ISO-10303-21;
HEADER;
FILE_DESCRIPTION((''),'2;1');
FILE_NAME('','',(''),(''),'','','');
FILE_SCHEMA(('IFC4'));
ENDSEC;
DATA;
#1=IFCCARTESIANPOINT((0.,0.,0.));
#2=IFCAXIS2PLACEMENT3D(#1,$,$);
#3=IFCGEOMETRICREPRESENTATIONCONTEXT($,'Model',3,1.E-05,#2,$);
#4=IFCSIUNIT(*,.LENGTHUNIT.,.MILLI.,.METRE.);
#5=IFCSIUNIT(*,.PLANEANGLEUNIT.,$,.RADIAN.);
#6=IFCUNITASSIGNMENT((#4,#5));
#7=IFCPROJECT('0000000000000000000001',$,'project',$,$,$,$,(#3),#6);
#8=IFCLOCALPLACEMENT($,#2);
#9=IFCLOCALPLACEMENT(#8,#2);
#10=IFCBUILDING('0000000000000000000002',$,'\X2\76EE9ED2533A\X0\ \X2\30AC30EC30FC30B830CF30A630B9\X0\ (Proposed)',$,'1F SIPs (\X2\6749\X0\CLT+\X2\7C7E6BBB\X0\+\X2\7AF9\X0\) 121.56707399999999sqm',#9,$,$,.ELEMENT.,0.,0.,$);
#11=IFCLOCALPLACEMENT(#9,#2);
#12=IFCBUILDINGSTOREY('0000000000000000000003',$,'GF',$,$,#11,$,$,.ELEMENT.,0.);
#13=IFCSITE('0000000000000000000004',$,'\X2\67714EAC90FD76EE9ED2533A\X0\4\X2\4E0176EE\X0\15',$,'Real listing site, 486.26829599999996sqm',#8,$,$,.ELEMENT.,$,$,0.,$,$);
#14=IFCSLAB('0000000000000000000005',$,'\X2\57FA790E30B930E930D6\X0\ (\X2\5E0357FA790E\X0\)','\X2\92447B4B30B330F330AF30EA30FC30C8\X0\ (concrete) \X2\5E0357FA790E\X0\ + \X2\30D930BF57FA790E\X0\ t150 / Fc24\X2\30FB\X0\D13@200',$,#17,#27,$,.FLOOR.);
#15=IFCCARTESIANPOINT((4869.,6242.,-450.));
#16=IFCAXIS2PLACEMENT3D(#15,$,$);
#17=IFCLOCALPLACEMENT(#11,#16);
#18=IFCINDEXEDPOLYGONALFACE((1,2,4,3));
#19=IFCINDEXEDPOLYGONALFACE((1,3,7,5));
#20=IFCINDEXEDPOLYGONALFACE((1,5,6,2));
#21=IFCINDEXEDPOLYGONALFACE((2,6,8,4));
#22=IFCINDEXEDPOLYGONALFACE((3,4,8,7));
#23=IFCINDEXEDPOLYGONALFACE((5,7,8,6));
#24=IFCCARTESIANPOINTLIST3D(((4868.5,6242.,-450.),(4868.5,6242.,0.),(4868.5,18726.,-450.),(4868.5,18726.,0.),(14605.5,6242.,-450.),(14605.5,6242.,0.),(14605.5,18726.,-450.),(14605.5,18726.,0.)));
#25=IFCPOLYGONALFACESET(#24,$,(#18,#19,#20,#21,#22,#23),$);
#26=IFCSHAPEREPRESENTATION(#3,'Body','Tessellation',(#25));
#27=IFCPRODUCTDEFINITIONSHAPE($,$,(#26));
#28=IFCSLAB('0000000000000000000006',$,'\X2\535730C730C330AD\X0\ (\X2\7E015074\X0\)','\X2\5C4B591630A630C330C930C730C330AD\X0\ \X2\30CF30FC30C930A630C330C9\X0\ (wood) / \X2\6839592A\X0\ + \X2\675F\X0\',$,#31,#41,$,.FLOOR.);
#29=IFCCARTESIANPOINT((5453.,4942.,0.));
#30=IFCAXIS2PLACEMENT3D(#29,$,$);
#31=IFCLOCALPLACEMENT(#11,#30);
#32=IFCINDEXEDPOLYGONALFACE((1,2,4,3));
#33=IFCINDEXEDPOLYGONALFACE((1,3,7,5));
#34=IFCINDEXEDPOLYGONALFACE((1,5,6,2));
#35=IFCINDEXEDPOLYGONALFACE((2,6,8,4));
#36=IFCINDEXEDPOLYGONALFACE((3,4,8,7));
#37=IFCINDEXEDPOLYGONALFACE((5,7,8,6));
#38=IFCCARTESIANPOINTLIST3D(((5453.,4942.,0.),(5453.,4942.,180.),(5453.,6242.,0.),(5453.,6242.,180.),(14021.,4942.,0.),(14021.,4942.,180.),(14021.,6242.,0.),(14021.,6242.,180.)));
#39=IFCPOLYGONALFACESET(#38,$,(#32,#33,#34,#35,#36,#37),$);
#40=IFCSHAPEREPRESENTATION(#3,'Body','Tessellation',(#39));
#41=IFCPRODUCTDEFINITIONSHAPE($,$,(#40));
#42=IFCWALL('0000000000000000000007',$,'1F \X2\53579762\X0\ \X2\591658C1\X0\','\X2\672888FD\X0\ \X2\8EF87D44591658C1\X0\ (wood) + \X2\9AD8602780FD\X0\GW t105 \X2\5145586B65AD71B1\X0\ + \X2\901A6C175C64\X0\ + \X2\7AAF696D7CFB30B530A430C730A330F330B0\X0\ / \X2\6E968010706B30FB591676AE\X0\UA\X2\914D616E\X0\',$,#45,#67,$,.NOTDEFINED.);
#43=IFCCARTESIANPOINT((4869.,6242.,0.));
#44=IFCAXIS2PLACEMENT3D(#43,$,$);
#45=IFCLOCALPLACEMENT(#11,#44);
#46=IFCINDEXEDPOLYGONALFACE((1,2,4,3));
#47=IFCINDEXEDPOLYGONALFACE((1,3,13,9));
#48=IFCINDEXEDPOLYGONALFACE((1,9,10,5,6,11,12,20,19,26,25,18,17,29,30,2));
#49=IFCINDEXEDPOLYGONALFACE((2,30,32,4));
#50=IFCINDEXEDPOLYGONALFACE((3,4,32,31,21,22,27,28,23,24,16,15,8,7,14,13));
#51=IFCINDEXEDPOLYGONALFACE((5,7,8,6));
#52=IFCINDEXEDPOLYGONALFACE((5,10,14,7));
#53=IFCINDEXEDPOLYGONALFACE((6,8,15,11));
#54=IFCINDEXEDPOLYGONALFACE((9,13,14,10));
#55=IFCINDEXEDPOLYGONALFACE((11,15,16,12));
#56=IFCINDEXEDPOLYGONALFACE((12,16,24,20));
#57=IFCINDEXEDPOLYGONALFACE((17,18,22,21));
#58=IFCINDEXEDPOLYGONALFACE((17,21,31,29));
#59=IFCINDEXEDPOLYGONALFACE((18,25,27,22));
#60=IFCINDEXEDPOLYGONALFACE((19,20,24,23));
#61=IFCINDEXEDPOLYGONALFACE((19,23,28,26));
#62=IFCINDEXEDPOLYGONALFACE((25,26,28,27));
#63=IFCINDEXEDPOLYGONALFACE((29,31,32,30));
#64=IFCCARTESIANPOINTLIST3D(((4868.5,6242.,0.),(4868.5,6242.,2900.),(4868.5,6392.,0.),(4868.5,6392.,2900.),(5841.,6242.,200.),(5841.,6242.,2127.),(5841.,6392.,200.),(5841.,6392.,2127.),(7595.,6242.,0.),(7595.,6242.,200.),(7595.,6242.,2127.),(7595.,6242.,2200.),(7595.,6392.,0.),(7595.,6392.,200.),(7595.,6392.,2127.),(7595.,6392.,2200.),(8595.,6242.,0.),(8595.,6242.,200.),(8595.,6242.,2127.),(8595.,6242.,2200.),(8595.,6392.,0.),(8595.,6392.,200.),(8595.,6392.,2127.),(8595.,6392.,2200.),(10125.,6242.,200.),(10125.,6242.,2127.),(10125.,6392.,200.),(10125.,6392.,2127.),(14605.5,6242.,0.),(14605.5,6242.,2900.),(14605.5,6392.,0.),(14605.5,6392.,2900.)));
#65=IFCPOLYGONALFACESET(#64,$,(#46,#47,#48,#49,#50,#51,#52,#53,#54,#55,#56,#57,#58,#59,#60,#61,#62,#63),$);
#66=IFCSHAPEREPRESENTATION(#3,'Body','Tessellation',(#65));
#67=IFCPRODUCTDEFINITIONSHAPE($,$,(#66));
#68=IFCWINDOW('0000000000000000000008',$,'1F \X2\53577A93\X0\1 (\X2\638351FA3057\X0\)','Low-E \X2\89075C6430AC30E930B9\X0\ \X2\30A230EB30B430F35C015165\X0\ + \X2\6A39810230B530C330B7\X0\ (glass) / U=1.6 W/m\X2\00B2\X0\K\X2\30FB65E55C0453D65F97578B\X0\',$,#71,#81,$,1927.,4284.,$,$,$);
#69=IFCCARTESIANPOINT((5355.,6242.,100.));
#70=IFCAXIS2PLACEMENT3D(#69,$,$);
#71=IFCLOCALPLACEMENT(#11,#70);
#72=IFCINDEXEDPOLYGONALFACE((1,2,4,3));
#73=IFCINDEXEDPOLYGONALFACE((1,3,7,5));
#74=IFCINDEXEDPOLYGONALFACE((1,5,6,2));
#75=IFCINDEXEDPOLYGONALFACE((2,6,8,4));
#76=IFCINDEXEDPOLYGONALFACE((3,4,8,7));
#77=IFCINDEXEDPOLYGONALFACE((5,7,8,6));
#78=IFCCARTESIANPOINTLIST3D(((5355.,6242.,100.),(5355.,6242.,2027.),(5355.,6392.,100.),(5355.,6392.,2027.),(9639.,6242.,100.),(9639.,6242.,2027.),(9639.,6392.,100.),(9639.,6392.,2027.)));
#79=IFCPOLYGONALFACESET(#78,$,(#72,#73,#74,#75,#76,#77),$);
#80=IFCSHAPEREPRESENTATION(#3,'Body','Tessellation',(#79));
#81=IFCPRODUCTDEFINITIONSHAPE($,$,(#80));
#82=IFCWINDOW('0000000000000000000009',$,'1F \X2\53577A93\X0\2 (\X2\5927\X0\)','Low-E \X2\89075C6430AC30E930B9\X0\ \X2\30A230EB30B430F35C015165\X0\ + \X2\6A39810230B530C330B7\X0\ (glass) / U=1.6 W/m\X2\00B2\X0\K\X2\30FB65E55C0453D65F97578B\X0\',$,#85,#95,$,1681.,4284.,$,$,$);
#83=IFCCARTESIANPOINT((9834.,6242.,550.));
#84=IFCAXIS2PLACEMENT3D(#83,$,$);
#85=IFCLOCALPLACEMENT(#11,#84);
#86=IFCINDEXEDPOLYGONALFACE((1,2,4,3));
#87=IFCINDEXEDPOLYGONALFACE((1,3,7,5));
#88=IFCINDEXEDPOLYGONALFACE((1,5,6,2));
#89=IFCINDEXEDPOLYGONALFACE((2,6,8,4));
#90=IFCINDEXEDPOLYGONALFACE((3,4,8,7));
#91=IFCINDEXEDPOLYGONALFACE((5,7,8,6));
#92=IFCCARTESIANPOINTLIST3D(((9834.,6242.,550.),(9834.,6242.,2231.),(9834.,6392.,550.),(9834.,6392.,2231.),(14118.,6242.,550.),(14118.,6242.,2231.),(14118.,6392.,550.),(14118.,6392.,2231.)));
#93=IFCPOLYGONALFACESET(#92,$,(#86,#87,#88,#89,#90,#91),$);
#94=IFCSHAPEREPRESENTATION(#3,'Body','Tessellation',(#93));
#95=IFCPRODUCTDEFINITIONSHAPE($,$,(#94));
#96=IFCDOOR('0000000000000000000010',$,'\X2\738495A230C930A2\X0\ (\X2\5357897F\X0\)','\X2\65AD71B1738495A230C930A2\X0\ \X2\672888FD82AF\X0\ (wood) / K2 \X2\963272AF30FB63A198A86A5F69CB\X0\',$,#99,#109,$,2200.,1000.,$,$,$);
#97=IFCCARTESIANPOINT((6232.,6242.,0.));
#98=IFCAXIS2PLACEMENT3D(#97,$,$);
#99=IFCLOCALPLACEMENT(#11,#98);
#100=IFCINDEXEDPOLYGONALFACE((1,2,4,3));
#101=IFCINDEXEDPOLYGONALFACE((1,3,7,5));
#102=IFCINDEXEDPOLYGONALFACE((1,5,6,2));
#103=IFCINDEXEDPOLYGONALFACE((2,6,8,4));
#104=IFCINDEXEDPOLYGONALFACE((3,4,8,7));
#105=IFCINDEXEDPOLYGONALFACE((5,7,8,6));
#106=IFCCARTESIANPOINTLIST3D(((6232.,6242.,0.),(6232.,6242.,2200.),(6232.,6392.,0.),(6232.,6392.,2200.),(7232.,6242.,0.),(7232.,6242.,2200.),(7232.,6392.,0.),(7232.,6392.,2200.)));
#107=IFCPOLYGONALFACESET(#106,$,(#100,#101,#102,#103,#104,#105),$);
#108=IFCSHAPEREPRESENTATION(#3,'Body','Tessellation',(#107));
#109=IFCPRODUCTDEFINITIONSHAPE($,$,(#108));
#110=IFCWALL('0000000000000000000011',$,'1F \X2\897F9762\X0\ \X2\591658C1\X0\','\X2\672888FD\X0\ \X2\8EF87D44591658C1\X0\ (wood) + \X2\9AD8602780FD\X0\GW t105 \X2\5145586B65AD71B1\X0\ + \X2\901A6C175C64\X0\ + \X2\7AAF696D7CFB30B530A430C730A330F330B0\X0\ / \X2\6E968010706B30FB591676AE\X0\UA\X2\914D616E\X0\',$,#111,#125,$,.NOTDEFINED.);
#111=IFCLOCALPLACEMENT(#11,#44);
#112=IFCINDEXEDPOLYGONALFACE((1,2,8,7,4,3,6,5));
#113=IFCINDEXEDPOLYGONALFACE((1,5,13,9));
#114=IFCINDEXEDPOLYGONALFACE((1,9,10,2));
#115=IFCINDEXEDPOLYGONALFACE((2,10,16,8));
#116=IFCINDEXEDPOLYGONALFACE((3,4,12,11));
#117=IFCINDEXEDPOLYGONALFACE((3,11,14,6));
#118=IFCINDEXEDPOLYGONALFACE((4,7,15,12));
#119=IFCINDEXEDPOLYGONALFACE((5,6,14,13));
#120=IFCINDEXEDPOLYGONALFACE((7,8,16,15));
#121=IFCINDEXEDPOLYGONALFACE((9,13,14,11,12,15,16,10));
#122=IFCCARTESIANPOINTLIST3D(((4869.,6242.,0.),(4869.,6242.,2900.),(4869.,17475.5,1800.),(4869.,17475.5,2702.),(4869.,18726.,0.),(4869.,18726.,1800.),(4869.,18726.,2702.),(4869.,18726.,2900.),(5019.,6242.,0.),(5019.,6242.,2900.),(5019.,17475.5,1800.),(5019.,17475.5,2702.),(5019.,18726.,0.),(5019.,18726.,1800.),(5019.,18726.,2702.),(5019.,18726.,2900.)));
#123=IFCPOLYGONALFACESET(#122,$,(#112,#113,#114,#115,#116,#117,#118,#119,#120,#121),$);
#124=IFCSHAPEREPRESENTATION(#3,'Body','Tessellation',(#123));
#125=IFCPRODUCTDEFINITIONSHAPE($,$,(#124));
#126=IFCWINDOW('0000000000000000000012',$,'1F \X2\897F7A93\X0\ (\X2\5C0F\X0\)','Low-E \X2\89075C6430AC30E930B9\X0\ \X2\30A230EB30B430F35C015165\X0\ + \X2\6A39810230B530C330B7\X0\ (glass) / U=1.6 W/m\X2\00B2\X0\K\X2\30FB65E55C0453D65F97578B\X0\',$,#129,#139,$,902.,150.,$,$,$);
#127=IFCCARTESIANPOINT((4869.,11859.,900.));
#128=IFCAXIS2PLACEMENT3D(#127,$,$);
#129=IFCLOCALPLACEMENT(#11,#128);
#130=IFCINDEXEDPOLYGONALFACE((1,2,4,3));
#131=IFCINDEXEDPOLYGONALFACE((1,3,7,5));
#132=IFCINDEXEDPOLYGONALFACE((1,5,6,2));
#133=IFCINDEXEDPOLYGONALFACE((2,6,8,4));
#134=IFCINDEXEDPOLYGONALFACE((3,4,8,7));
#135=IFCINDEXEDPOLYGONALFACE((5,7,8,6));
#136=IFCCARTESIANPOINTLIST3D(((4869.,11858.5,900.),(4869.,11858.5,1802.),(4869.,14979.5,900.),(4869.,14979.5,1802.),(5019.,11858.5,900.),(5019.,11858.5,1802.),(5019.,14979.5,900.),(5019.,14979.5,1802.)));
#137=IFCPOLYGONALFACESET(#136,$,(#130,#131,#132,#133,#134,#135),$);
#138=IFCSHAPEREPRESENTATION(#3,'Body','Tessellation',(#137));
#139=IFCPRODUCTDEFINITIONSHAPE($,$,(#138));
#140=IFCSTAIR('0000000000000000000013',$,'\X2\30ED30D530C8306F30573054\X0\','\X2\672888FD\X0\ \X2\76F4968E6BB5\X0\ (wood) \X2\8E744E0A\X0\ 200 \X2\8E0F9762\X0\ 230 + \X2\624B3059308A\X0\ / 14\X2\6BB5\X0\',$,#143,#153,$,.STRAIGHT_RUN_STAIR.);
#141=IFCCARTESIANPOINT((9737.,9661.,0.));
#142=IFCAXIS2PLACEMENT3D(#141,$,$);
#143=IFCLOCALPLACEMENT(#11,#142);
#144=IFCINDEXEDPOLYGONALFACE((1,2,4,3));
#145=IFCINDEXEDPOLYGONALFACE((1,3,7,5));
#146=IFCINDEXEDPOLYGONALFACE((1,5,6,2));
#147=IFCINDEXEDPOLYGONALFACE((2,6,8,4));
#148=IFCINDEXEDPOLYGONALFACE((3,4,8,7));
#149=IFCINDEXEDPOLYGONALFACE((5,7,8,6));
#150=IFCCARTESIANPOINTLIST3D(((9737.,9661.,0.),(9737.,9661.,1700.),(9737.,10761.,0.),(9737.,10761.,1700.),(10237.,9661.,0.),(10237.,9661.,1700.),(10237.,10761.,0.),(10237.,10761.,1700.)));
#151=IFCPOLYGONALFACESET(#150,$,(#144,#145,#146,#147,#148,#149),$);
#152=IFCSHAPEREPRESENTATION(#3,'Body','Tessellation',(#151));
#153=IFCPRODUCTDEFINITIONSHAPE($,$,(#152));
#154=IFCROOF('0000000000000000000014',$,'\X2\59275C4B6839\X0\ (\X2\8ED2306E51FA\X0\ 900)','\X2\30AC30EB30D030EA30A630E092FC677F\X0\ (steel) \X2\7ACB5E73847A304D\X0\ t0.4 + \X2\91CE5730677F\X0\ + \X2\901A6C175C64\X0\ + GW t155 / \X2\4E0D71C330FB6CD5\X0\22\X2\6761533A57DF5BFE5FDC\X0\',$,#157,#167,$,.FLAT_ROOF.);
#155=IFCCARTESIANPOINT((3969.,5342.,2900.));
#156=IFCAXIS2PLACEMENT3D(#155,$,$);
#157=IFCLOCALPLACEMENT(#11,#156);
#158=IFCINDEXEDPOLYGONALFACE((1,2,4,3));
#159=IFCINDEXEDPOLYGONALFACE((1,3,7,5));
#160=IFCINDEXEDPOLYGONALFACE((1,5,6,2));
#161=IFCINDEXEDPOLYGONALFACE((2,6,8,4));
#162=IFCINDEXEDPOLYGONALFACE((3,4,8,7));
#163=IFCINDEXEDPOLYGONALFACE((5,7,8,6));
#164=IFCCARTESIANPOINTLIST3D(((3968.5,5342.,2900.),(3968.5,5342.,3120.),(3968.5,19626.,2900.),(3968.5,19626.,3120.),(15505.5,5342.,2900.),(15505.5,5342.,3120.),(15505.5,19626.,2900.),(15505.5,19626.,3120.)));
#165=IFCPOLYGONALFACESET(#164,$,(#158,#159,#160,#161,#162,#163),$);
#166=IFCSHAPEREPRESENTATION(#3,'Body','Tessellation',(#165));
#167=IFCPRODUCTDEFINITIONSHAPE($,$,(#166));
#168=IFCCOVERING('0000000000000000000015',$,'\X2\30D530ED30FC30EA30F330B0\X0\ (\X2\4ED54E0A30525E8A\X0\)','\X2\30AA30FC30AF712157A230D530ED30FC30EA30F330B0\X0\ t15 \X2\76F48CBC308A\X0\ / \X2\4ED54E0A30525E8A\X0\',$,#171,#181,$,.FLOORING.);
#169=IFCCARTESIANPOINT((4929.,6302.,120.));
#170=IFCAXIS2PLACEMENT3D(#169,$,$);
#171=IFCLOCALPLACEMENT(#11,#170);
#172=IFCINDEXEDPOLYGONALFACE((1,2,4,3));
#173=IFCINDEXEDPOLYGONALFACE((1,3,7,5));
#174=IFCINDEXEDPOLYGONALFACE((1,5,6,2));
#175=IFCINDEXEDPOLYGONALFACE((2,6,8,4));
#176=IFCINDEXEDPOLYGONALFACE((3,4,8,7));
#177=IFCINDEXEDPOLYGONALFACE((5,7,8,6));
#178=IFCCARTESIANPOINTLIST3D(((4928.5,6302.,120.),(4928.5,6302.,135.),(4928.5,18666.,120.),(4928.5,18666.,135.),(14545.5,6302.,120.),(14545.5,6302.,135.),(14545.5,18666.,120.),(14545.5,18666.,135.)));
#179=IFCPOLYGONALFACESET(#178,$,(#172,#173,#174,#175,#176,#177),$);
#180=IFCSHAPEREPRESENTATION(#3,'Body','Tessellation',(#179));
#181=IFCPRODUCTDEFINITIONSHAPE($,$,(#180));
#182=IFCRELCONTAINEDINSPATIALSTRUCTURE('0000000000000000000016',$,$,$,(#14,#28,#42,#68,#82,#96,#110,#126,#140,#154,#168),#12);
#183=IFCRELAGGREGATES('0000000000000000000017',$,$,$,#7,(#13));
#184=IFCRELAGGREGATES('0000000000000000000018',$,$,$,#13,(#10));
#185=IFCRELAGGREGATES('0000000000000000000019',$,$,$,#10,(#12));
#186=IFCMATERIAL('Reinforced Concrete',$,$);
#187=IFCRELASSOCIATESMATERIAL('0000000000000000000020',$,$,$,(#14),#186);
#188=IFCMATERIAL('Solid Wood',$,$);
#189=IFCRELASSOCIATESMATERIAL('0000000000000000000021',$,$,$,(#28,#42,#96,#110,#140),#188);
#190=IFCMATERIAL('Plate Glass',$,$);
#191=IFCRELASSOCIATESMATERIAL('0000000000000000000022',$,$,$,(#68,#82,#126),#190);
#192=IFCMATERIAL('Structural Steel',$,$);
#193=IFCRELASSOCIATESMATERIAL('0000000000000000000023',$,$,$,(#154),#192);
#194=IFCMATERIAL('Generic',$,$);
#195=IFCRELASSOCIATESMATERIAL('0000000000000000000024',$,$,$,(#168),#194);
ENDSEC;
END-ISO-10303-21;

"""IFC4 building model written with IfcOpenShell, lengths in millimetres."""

from ifc_helpers import new_model, si_unit, frame, frame_2d, origin, place, context, project, spatial, rectangle, extrude, material, element, fill, save


model = new_model("IFC4")

# Units and contexts
model_context = context("Model", 3, precision=1e-05, world=origin())
ifc_project = project(units=[si_unit("LENGTHUNIT", "METRE", prefix="MILLI"), si_unit("PLANEANGLEUNIT", "RADIAN")], contexts=[model_context])

# Site, building, storey
site_placement = place(None, origin())
site = spatial("IfcSite", under=ifc_project, at=site_placement, Name="東京都目黒区4丁目15", ObjectType="Real listing site, 486.26829599999996sqm", CompositionType="ELEMENT", RefElevation=0.0)
building_placement = place(site_placement, origin())
building = spatial("IfcBuilding", under=site, at=building_placement, Name="目黒区 ガレージハウス (Proposed)", ObjectType="1F SIPs (杉CLT+籾殻+竹) 121.56707399999999sqm", CompositionType="ELEMENT", ElevationOfRefHeight=0.0, ElevationOfTerrain=0.0)
storey_placement = place(building_placement, origin())
storey = spatial("IfcBuildingStorey", under=building, at=storey_placement, Name="GF", CompositionType="ELEMENT", Elevation=0.0)

# Slabs
ifc_material_1 = material(Name="Reinforced Concrete")
slab_1_placement = place(storey_placement, frame((4869.0, 6242.0, -450.0)))
element("IfcSlab", 1, at=slab_1_placement, inside=storey, material=ifc_material_1, Name="基礎スラブ (布基礎)", Description="鉄筋コンクリート (concrete) 布基礎 + ベタ基礎 t150 / Fc24・D13@200", PredefinedType="FLOOR", context=model_context, shape_type="SweptSolid", body=[
    extrude(rectangle(XDim=9737.0, YDim=12484.0, at=frame_2d((4868.0, 6242.0))), frame((4869.0, 6242.0, -450.0)), (0.0, 0.0, 1.0), 450.0),
])
ifc_material_2 = material(Name="Solid Wood")
slab_2_placement = place(storey_placement, frame((5453.0, 4942.0, 0.0)))
element("IfcSlab", 2, at=slab_2_placement, inside=storey, material=ifc_material_2, Name="南デッキ (縁側)", Description="屋外ウッドデッキ ハードウッド (wood) / 根太 + 束", PredefinedType="FLOOR", context=model_context, shape_type="SweptSolid", body=[
    extrude(rectangle(XDim=8568.0, YDim=1300.0, at=frame_2d((4284.0, 650.0))), frame((5453.0, 4942.0, 0.0)), (0.0, 0.0, 1.0), 180.0),
])

# Wall, openings, windows, door
wall_1_placement = place(storey_placement, frame((4869.0, 6242.0, 0.0)))
wall_1 = element("IfcWall", 3, at=wall_1_placement, inside=storey, material=ifc_material_2, Name="1F 南面 外壁", Description="木製 軸組外壁 (wood) + 高性能GW t105 充填断熱 + 通気層 + 窯業系サイディング / 準耐火・外皮UA配慮", PredefinedType="NOTDEFINED", context=model_context, shape_type="SweptSolid", body=[
    extrude(rectangle(XDim=9737.0, YDim=150.0, at=frame_2d((4868.0, 75.0))), frame((4869.0, 6242.0, 0.0)), (0.0, 0.0, 1.0), 2900.0),
])
opening_1_placement = place(storey_placement, frame((5355.0, 6242.0, 100.0)))
opening_1 = element("IfcOpeningElement", 4, at=opening_1_placement, cuts=wall_1, PredefinedType="NOTDEFINED", context=model_context, shape_type="SweptSolid", body=[
    extrude(rectangle(XDim=4284.0, YDim=150.0, at=frame_2d((2142.0, 75.0))), frame((5355.0, 6242.0, 100.0)), (0.0, 0.0, 1.0), 1927.0),
])
opening_2_placement = place(storey_placement, frame((9834.0, 6242.0, 550.0)))
opening_2 = element("IfcOpeningElement", 5, at=opening_2_placement, cuts=wall_1, PredefinedType="NOTDEFINED", context=model_context, shape_type="SweptSolid", body=[
    extrude(rectangle(XDim=4284.0, YDim=150.0, at=frame_2d((2142.0, 75.0))), frame((9834.0, 6242.0, 550.0)), (0.0, 0.0, 1.0), 1681.0),
])
opening_3_placement = place(storey_placement, frame((6232.0, 6242.0, 0.0)))
opening_3 = element("IfcOpeningElement", 6, at=opening_3_placement, cuts=wall_1, PredefinedType="NOTDEFINED", context=model_context, shape_type="SweptSolid", body=[
    extrude(rectangle(XDim=1000.0, YDim=150.0, at=frame_2d((500.0, 75.0))), frame((6232.0, 6242.0, 0.0)), (0.0, 0.0, 1.0), 2200.0),
])
ifc_material_3 = material(Name="Plate Glass")
window_1_placement = place(storey_placement, frame((5355.0, 6242.0, 100.0)))
window_1 = element("IfcWindow", 7, at=window_1_placement, inside=storey, material=ifc_material_3, Name="1F 南窓1 (掃出し)", Description="Low-E 複層ガラス アルゴン封入 + 樹脂サッシ (glass) / U=1.6 W/m²K・日射取得型", OverallHeight=1927.0, OverallWidth=4284.0, context=model_context, shape_type="SweptSolid", body=[
    extrude(rectangle(XDim=4284.0, YDim=150.0, at=frame_2d((2142.0, 75.0))), frame((5355.0, 6242.0, 100.0)), (0.0, 0.0, 1.0), 1927.0),
])
fill(opening_1, window_1)
window_2_placement = place(storey_placement, frame((9834.0, 6242.0, 550.0)))
window_2 = element("IfcWindow", 8, at=window_2_placement, inside=storey, material=ifc_material_3, Name="1F 南窓2 (大)", Description="Low-E 複層ガラス アルゴン封入 + 樹脂サッシ (glass) / U=1.6 W/m²K・日射取得型", OverallHeight=1681.0, OverallWidth=4284.0, context=model_context, shape_type="SweptSolid", body=[
    extrude(rectangle(XDim=4284.0, YDim=150.0, at=frame_2d((2142.0, 75.0))), frame((9834.0, 6242.0, 550.0)), (0.0, 0.0, 1.0), 1681.0),
])
fill(opening_2, window_2)
door_placement = place(storey_placement, frame((6232.0, 6242.0, 0.0)))
door = element("IfcDoor", 9, at=door_placement, inside=storey, material=ifc_material_2, Name="玄関ドア (南西)", Description="断熱玄関ドア 木製芯 (wood) / K2 防犯・採風機構", OverallHeight=2200.0, OverallWidth=1000.0, context=model_context, shape_type="SweptSolid", body=[
    extrude(rectangle(XDim=1000.0, YDim=150.0, at=frame_2d((500.0, 75.0))), frame((6232.0, 6242.0, 0.0)), (0.0, 0.0, 1.0), 2200.0),
])
fill(opening_3, door)

# Wall, opening, window
wall_2_placement = place(storey_placement, frame((4869.0, 6242.0, 0.0)))
wall_2 = element("IfcWall", 10, at=wall_2_placement, inside=storey, material=ifc_material_2, Name="1F 西面 外壁", Description="木製 軸組外壁 (wood) + 高性能GW t105 充填断熱 + 通気層 + 窯業系サイディング / 準耐火・外皮UA配慮", PredefinedType="NOTDEFINED", context=model_context, shape_type="SweptSolid", body=[
    extrude(rectangle(XDim=150.0, YDim=12484.0, at=frame_2d((75.0, 6242.0))), frame((4869.0, 6242.0, 0.0)), (0.0, 0.0, 1.0), 2900.0),
])
opening_4_placement = place(storey_placement, frame((4869.0, 11859.0, 900.0)))
opening_4 = element("IfcOpeningElement", 11, at=opening_4_placement, cuts=wall_2, PredefinedType="NOTDEFINED", context=model_context, shape_type="SweptSolid", body=[
    extrude(rectangle(XDim=150.0, YDim=3121.0, at=frame_2d((75.0, 1560.0))), frame((4869.0, 11859.0, 900.0)), (0.0, 0.0, 1.0), 902.0),
])
window_3_placement = place(storey_placement, frame((4869.0, 11859.0, 900.0)))
window_3 = element("IfcWindow", 12, at=window_3_placement, inside=storey, material=ifc_material_3, Name="1F 西窓 (小)", Description="Low-E 複層ガラス アルゴン封入 + 樹脂サッシ (glass) / U=1.6 W/m²K・日射取得型", OverallHeight=902.0, OverallWidth=150.0, context=model_context, shape_type="SweptSolid", body=[
    extrude(rectangle(XDim=150.0, YDim=3121.0, at=frame_2d((75.0, 1560.0))), frame((4869.0, 11859.0, 900.0)), (0.0, 0.0, 1.0), 902.0),
])
fill(opening_4, window_3)

# Stair
stair_placement = place(storey_placement, frame((9737.0, 9661.0, 0.0)))
element("IfcStair", 13, at=stair_placement, inside=storey, material=ifc_material_2, Name="ロフトはしご", Description="木製 直階段 (wood) 蹴上 200 踏面 230 + 手すり / 14段", PredefinedType="STRAIGHT_RUN_STAIR", context=model_context, shape_type="SweptSolid", body=[
    extrude(rectangle(XDim=500.0, YDim=1100.0, at=frame_2d((250.0, 550.0))), frame((9737.0, 9661.0, 0.0)), (0.0, 0.0, 1.0), 1700.0),
])

# Roof
ifc_material_4 = material(Name="Structural Steel")
roof_placement = place(storey_placement, frame((3969.0, 5342.0, 2900.0)))
element("IfcRoof", 14, at=roof_placement, inside=storey, material=ifc_material_4, Name="大屋根 (軒の出 900)", Description="ガルバリウム鋼板 (steel) 立平葺き t0.4 + 野地板 + 通気層 + GW t155 / 不燃・法22条区域対応", PredefinedType="FLAT_ROOF", context=model_context, shape_type="SweptSolid", body=[
    extrude(rectangle(XDim=11537.0, YDim=14284.0, at=frame_2d((5768.0, 7142.0))), frame((3969.0, 5342.0, 2900.0)), (0.0, 0.0, 1.0), 220.0),
])

# Covering
ifc_material_5 = material(Name="Generic")
covering_placement = place(storey_placement, frame((4929.0, 6302.0, 120.0)))
element("IfcCovering", 15, at=covering_placement, inside=storey, material=ifc_material_5, Name="フローリング (仕上げ床)", Description="オーク無垢フローリング t15 直貼り / 仕上げ床", PredefinedType="FLOORING", context=model_context, shape_type="SweptSolid", body=[
    extrude(rectangle(XDim=9617.0, YDim=12364.0, at=frame_2d((4808.0, 6182.0))), frame((4929.0, 6302.0, 120.0)), (0.0, 0.0, 1.0), 15.0),
])

save(model, "model.ifc")
